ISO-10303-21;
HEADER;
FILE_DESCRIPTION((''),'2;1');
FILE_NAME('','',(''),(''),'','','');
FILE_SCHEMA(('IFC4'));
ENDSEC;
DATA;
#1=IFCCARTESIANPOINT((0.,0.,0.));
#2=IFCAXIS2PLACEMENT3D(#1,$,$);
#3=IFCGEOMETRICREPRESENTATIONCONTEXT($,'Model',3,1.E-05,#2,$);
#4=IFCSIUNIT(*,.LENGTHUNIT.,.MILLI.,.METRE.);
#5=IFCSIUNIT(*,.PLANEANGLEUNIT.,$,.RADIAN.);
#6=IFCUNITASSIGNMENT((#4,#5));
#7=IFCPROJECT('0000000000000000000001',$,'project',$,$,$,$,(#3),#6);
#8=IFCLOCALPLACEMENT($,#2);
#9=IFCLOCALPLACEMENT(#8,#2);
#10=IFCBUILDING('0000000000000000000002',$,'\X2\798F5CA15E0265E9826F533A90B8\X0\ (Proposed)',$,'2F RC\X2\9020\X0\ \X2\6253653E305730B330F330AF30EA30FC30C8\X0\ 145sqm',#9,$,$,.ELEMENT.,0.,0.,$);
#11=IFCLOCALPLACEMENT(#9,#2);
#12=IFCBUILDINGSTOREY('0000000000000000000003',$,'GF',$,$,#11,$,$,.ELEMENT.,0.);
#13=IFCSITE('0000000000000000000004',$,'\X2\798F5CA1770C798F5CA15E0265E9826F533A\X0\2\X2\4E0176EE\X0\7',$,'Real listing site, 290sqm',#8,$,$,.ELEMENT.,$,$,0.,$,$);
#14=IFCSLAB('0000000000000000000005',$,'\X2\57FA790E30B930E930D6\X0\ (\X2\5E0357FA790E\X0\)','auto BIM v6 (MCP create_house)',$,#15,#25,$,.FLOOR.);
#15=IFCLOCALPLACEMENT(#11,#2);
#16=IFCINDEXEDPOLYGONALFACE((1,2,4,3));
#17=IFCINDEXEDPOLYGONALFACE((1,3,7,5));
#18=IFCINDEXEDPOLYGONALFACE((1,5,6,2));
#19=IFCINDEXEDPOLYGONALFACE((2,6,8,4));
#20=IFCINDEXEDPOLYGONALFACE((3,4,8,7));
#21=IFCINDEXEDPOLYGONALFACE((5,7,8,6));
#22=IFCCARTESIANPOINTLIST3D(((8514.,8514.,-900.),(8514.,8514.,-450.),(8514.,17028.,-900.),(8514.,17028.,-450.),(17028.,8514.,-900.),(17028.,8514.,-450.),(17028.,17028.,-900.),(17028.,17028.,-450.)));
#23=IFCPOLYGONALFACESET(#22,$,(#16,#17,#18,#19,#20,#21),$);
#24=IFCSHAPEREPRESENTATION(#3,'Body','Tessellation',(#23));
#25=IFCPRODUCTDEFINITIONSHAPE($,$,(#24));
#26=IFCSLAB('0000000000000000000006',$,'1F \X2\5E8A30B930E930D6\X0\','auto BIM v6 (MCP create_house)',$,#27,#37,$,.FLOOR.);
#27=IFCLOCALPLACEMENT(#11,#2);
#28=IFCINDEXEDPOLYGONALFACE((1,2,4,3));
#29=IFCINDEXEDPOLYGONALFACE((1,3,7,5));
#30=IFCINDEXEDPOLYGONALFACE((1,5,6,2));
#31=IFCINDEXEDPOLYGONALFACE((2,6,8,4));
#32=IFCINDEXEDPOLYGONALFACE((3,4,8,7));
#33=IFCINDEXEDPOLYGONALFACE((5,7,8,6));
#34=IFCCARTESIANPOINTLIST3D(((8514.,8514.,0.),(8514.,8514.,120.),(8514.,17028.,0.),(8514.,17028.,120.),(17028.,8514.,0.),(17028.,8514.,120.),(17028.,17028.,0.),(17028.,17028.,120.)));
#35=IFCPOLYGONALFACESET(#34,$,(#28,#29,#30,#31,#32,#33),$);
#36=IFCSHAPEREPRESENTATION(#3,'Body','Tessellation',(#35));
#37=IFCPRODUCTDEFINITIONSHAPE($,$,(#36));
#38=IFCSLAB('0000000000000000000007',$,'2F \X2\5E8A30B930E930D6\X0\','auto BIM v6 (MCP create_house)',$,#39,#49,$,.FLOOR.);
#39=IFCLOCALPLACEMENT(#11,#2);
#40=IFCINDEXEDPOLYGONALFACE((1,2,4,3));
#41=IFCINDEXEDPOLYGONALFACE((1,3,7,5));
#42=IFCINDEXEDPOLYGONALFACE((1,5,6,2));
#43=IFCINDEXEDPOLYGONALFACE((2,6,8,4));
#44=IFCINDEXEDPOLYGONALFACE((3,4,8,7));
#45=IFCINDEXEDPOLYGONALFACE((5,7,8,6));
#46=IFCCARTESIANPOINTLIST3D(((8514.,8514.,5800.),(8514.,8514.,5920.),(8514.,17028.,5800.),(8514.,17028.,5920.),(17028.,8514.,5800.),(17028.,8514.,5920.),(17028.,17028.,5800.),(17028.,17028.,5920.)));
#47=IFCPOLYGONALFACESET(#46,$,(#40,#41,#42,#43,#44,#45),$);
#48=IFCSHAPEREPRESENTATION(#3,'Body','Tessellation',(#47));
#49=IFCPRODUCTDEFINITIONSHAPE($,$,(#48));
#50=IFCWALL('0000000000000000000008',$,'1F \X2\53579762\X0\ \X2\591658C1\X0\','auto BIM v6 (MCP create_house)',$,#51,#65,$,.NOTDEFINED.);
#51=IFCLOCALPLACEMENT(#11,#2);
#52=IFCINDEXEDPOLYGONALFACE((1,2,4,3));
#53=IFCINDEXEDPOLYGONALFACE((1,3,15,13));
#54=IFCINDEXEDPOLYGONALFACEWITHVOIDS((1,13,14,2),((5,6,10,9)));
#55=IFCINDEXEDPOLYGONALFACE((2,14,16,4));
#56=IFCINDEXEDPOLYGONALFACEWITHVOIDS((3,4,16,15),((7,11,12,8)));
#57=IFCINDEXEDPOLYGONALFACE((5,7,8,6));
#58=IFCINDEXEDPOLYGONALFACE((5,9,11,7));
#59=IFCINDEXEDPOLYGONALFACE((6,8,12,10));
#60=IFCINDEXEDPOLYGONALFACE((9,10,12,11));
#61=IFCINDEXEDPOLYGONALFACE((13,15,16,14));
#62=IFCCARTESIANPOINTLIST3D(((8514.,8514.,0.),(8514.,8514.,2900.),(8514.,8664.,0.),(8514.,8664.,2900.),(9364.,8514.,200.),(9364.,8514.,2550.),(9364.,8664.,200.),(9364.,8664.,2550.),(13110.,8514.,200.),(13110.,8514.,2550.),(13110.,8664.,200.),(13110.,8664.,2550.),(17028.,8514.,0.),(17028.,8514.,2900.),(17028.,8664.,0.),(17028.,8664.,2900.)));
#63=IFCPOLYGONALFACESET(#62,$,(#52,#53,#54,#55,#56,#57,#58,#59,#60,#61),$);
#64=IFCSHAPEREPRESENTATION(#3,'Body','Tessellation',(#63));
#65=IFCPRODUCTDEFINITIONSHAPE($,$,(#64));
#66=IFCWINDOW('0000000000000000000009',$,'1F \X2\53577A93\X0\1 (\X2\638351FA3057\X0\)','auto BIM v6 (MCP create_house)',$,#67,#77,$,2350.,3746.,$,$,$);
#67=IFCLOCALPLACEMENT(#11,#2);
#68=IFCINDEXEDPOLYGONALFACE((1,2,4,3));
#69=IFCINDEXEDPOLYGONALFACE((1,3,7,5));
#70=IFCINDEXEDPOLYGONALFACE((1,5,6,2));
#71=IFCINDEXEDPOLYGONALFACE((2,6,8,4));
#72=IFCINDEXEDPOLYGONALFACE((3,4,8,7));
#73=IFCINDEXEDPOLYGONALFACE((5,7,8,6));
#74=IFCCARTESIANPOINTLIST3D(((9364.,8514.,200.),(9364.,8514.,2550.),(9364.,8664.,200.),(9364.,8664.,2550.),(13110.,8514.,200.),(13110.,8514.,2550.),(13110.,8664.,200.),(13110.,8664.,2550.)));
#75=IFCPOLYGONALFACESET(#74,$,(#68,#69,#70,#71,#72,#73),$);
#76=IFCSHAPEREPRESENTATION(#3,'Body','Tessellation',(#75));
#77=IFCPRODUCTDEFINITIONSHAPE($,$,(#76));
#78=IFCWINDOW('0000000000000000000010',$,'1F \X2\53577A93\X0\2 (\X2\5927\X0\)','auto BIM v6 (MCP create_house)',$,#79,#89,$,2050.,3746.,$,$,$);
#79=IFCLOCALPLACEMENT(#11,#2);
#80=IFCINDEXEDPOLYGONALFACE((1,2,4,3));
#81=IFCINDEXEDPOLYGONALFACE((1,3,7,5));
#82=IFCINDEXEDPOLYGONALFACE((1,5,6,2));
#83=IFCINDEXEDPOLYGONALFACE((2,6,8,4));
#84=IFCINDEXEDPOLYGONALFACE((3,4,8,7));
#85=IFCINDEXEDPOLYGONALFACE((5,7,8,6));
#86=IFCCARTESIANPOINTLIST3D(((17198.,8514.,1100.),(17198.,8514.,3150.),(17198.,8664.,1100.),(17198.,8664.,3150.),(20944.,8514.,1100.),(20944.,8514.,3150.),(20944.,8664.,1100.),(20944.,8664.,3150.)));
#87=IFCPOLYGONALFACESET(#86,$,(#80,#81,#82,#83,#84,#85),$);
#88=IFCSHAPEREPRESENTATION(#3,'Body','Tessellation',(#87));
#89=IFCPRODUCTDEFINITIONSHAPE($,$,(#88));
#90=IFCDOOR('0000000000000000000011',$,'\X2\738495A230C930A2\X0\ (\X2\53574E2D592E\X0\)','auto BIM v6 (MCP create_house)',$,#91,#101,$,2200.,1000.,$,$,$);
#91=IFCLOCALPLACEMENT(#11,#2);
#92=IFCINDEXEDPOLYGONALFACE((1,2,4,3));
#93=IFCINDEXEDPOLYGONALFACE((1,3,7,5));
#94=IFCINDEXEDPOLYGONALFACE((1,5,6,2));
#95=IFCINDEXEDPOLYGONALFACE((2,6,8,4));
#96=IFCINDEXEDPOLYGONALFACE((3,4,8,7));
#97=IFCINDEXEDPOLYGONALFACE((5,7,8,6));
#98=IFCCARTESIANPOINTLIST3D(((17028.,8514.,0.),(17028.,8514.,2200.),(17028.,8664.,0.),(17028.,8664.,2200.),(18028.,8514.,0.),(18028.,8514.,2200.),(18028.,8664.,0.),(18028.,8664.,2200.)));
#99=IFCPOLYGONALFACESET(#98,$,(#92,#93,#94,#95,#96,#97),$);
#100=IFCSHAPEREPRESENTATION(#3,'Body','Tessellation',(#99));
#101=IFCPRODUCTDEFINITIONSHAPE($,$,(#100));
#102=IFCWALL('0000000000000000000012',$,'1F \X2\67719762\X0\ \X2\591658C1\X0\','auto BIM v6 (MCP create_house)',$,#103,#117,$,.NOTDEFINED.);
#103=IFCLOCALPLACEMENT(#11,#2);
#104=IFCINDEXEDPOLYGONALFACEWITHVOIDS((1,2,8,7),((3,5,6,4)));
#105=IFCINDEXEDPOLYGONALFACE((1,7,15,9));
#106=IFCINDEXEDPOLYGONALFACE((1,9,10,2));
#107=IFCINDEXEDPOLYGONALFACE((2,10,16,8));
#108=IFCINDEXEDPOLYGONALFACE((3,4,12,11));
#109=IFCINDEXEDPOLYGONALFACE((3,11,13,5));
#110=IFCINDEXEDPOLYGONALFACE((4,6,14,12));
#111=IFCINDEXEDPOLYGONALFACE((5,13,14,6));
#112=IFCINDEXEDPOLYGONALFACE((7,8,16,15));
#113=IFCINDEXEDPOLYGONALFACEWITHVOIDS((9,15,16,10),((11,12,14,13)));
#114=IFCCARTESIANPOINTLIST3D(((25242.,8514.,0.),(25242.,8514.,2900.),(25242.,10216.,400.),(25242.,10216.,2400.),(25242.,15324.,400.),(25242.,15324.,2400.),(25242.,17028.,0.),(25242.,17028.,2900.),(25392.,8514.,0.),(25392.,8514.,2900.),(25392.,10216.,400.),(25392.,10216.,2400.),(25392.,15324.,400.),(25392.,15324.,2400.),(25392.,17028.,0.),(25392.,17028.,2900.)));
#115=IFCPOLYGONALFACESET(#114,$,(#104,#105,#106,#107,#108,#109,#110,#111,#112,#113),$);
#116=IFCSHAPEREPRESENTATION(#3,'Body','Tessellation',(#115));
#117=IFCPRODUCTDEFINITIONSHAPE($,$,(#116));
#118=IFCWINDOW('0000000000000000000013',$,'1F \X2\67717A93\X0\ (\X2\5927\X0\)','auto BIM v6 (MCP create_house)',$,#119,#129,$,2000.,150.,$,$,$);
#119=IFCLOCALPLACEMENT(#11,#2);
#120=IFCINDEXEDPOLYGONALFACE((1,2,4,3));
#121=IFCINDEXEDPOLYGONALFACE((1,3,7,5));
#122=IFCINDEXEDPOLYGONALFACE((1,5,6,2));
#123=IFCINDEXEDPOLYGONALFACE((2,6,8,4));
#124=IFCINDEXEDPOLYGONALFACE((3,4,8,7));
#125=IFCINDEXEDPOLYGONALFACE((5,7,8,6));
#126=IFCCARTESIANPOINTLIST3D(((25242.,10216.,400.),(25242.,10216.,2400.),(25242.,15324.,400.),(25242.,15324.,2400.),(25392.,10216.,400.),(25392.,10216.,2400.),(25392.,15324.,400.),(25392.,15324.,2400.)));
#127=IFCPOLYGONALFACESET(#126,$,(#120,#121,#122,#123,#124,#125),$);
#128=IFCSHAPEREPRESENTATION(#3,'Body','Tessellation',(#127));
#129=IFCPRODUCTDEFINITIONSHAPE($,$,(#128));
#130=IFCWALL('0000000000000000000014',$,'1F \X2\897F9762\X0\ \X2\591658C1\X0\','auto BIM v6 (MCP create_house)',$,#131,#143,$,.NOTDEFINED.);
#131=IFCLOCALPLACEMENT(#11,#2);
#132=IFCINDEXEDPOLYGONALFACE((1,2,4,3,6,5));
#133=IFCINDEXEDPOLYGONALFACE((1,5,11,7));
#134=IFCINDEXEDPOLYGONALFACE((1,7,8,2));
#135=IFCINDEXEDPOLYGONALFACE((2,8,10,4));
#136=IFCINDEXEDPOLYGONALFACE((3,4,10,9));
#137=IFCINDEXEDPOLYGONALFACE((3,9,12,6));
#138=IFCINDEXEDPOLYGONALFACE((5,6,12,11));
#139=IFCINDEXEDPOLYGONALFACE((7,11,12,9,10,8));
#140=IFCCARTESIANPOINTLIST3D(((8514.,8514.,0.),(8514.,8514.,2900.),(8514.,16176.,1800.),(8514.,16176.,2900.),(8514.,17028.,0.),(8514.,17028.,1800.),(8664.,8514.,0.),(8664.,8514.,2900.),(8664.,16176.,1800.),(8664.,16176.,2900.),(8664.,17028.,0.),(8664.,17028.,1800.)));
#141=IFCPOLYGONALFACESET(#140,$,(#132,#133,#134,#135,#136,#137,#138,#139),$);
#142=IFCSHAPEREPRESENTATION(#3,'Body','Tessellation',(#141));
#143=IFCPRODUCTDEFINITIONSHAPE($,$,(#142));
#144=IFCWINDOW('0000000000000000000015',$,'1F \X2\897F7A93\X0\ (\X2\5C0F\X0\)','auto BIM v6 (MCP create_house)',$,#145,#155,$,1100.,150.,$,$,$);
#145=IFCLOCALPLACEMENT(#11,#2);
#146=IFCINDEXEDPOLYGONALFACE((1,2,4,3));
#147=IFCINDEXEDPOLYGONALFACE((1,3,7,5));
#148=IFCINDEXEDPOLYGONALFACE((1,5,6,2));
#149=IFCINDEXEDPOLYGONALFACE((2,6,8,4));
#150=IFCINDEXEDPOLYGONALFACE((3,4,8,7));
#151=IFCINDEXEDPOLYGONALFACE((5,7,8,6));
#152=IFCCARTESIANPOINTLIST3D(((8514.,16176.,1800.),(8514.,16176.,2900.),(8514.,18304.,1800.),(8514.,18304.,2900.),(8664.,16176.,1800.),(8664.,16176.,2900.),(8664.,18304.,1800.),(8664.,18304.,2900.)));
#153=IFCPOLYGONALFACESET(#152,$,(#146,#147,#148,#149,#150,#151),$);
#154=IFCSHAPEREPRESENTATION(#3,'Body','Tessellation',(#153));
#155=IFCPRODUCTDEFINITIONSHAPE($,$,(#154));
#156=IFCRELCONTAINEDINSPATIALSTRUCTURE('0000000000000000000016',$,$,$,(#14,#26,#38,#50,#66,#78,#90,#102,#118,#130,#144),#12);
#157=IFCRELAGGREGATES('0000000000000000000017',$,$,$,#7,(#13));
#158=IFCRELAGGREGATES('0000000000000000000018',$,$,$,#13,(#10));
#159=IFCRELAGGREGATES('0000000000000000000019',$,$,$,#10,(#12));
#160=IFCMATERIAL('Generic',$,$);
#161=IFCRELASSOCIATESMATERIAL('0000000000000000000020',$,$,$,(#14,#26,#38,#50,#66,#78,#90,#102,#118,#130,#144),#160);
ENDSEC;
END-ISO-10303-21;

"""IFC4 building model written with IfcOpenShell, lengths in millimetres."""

from ifc_helpers import new_model, si_unit, frame, frame_2d, origin, place, context, project, spatial, rectangle, extrude, material, element, fill, save


model = new_model("IFC4")

# Units and contexts
model_context = context("Model", 3, precision=1e-05, world=origin())
ifc_project = project(units=[si_unit("LENGTHUNIT", "METRE", prefix="MILLI"), si_unit("PLANEANGLEUNIT", "RADIAN")], contexts=[model_context])

# Site, building, storey
site_placement = place(None, origin())
site = spatial("IfcSite", under=ifc_project, at=site_placement, Name="福岡県福岡市早良区2丁目7", ObjectType="Real listing site, 290sqm", CompositionType="ELEMENT", RefElevation=0.0)
building_placement = place(site_placement, origin())
building = spatial("IfcBuilding", under=site, at=building_placement, Name="福岡市早良区邸 (Proposed)", ObjectType="2F RC造 打放しコンクリート 145sqm", CompositionType="ELEMENT", ElevationOfRefHeight=0.0, ElevationOfTerrain=0.0)
storey_placement = place(building_placement, origin())
storey = spatial("IfcBuildingStorey", under=building, at=storey_placement, Name="GF", CompositionType="ELEMENT", Elevation=0.0)

# Slabs
ifc_material = material(Name="Generic")
slab_1_placement = place(storey_placement, frame((4257.0, 4257.0, -450.0)))
element("IfcSlab", 1, at=slab_1_placement, inside=storey, material=ifc_material, Name="基礎スラブ (布基礎)", Description="auto BIM v6 (MCP create_house)", PredefinedType="FLOOR", context=model_context, shape_type="SweptSolid", body=[
    extrude(rectangle(XDim=8514.0, YDim=8514.0, at=frame_2d((4257.0, 4257.0))), frame((4257.0, 4257.0, -450.0)), (0.0, 0.0, 1.0), 450.0),
])
slab_2_placement = place(storey_placement, frame((4257.0, 4257.0, 0.0)))
element("IfcSlab", 2, at=slab_2_placement, inside=storey, material=ifc_material, Name="1F 床スラブ", Description="auto BIM v6 (MCP create_house)", PredefinedType="FLOOR", context=model_context, shape_type="SweptSolid", body=[
    extrude(rectangle(XDim=8514.0, YDim=8514.0, at=frame_2d((4257.0, 4257.0))), frame((4257.0, 4257.0, 0.0)), (0.0, 0.0, 1.0), 120.0),
])
slab_3_placement = place(storey_placement, frame((4257.0, 4257.0, 2900.0)))
element("IfcSlab", 3, at=slab_3_placement, inside=storey, material=ifc_material, Name="2F 床スラブ", Description="auto BIM v6 (MCP create_house)", PredefinedType="FLOOR", context=model_context, shape_type="SweptSolid", body=[
    extrude(rectangle(XDim=8514.0, YDim=8514.0, at=frame_2d((4257.0, 4257.0))), frame((4257.0, 4257.0, 2900.0)), (0.0, 0.0, 1.0), 120.0),
])

# Wall, openings, windows, door
wall_1_placement = place(storey_placement, frame((4257.0, 4257.0, 0.0)))
wall_1 = element("IfcWall", 4, at=wall_1_placement, inside=storey, material=ifc_material, Name="1F 南面 外壁", Description="auto BIM v6 (MCP create_house)", PredefinedType="NOTDEFINED", context=model_context, shape_type="SweptSolid", body=[
    extrude(rectangle(XDim=8514.0, YDim=150.0, at=frame_2d((4257.0, 75.0))), frame((4257.0, 4257.0, 0.0)), (0.0, 0.0, 1.0), 2900.0),
])
opening_1_placement = place(storey_placement, frame((4682.0, 4257.0, 100.0)))
opening_1 = element("IfcOpeningElement", 5, at=opening_1_placement, cuts=wall_1, PredefinedType="NOTDEFINED", context=model_context, shape_type="SweptSolid", body=[
    extrude(rectangle(XDim=3746.0, YDim=150.0, at=frame_2d((1873.0, 75.0))), frame((4682.0, 4257.0, 100.0)), (0.0, 0.0, 1.0), 2350.0),
])
opening_2_placement = place(storey_placement, frame((8599.0, 4257.0, 550.0)))
opening_2 = element("IfcOpeningElement", 6, at=opening_2_placement, cuts=wall_1, PredefinedType="NOTDEFINED", context=model_context, shape_type="SweptSolid", body=[
    extrude(rectangle(XDim=3746.0, YDim=150.0, at=frame_2d((1873.0, 75.0))), frame((8599.0, 4257.0, 550.0)), (0.0, 0.0, 1.0), 2050.0),
])
opening_3_placement = place(storey_placement, frame((8514.0, 4257.0, 0.0)))
opening_3 = element("IfcOpeningElement", 7, at=opening_3_placement, cuts=wall_1, PredefinedType="NOTDEFINED", context=model_context, shape_type="SweptSolid", body=[
    extrude(rectangle(XDim=1000.0, YDim=150.0, at=frame_2d((500.0, 75.0))), frame((8514.0, 4257.0, 0.0)), (0.0, 0.0, 1.0), 2200.0),
])
window_1_placement = place(storey_placement, frame((4682.0, 4257.0, 100.0)))
window_1 = element("IfcWindow", 8, at=window_1_placement, inside=storey, material=ifc_material, Name="1F 南窓1 (掃出し)", Description="auto BIM v6 (MCP create_house)", OverallHeight=2350.0, OverallWidth=3746.0, context=model_context, shape_type="SweptSolid", body=[
    extrude(rectangle(XDim=3746.0, YDim=150.0, at=frame_2d((1873.0, 75.0))), frame((4682.0, 4257.0, 100.0)), (0.0, 0.0, 1.0), 2350.0),
])
fill(opening_1, window_1)
window_2_placement = place(storey_placement, frame((8599.0, 4257.0, 550.0)))
window_2 = element("IfcWindow", 9, at=window_2_placement, inside=storey, material=ifc_material, Name="1F 南窓2 (大)", Description="auto BIM v6 (MCP create_house)", OverallHeight=2050.0, OverallWidth=3746.0, context=model_context, shape_type="SweptSolid", body=[
    extrude(rectangle(XDim=3746.0, YDim=150.0, at=frame_2d((1873.0, 75.0))), frame((8599.0, 4257.0, 550.0)), (0.0, 0.0, 1.0), 2050.0),
])
fill(opening_2, window_2)
door_placement = place(storey_placement, frame((8514.0, 4257.0, 0.0)))
door = element("IfcDoor", 10, at=door_placement, inside=storey, material=ifc_material, Name="玄関ドア (南中央)", Description="auto BIM v6 (MCP create_house)", OverallHeight=2200.0, OverallWidth=1000.0, context=model_context, shape_type="SweptSolid", body=[
    extrude(rectangle(XDim=1000.0, YDim=150.0, at=frame_2d((500.0, 75.0))), frame((8514.0, 4257.0, 0.0)), (0.0, 0.0, 1.0), 2200.0),
])
fill(opening_3, door)

# Walls, openings, windows
wall_2_placement = place(storey_placement, frame((12621.0, 4257.0, 0.0)))
wall_2 = element("IfcWall", 11, at=wall_2_placement, inside=storey, material=ifc_material, Name="1F 東面 外壁", Description="auto BIM v6 (MCP create_house)", PredefinedType="NOTDEFINED", context=model_context, shape_type="SweptSolid", body=[
    extrude(rectangle(XDim=150.0, YDim=8514.0, at=frame_2d((75.0, 4257.0))), frame((12621.0, 4257.0, 0.0)), (0.0, 0.0, 1.0), 2900.0),
])
opening_4_placement = place(storey_placement, frame((12621.0, 5108.0, 200.0)))
opening_4 = element("IfcOpeningElement", 12, at=opening_4_placement, cuts=wall_2, PredefinedType="NOTDEFINED", context=model_context, shape_type="SweptSolid", body=[
    extrude(rectangle(XDim=150.0, YDim=5108.0, at=frame_2d((75.0, 2554.0))), frame((12621.0, 5108.0, 200.0)), (0.0, 0.0, 1.0), 2000.0),
])
window_3_placement = place(storey_placement, frame((12621.0, 5108.0, 200.0)))
window_3 = element("IfcWindow", 13, at=window_3_placement, inside=storey, material=ifc_material, Name="1F 東窓 (大)", Description="auto BIM v6 (MCP create_house)", OverallHeight=2000.0, OverallWidth=150.0, context=model_context, shape_type="SweptSolid", body=[
    extrude(rectangle(XDim=150.0, YDim=5108.0, at=frame_2d((75.0, 2554.0))), frame((12621.0, 5108.0, 200.0)), (0.0, 0.0, 1.0), 2000.0),
])
fill(opening_4, window_3)
wall_3_placement = place(storey_placement, frame((4257.0, 4257.0, 0.0)))
wall_3 = element("IfcWall", 14, at=wall_3_placement, inside=storey, material=ifc_material, Name="1F 西面 外壁", Description="auto BIM v6 (MCP create_house)", PredefinedType="NOTDEFINED", context=model_context, shape_type="SweptSolid", body=[
    extrude(rectangle(XDim=150.0, YDim=8514.0, at=frame_2d((75.0, 4257.0))), frame((4257.0, 4257.0, 0.0)), (0.0, 0.0, 1.0), 2900.0),
])
opening_5_placement = place(storey_placement, frame((4257.0, 8088.0, 900.0)))
opening_5 = element("IfcOpeningElement", 15, at=opening_5_placement, cuts=wall_3, PredefinedType="NOTDEFINED", context=model_context, shape_type="SweptSolid", body=[
    extrude(rectangle(XDim=150.0, YDim=2128.0, at=frame_2d((75.0, 1064.0))), frame((4257.0, 8088.0, 900.0)), (0.0, 0.0, 1.0), 1100.0),
])
window_4_placement = place(storey_placement, frame((4257.0, 8088.0, 900.0)))
window_4 = element("IfcWindow", 16, at=window_4_placement, inside=storey, material=ifc_material, Name="1F 西窓 (小)", Description="auto BIM v6 (MCP create_house)", OverallHeight=1100.0, OverallWidth=150.0, context=model_context, shape_type="SweptSolid", body=[
    extrude(rectangle(XDim=150.0, YDim=2128.0, at=frame_2d((75.0, 1064.0))), frame((4257.0, 8088.0, 900.0)), (0.0, 0.0, 1.0), 1100.0),
])
fill(opening_5, window_4)

save(model, "model.ifc")
